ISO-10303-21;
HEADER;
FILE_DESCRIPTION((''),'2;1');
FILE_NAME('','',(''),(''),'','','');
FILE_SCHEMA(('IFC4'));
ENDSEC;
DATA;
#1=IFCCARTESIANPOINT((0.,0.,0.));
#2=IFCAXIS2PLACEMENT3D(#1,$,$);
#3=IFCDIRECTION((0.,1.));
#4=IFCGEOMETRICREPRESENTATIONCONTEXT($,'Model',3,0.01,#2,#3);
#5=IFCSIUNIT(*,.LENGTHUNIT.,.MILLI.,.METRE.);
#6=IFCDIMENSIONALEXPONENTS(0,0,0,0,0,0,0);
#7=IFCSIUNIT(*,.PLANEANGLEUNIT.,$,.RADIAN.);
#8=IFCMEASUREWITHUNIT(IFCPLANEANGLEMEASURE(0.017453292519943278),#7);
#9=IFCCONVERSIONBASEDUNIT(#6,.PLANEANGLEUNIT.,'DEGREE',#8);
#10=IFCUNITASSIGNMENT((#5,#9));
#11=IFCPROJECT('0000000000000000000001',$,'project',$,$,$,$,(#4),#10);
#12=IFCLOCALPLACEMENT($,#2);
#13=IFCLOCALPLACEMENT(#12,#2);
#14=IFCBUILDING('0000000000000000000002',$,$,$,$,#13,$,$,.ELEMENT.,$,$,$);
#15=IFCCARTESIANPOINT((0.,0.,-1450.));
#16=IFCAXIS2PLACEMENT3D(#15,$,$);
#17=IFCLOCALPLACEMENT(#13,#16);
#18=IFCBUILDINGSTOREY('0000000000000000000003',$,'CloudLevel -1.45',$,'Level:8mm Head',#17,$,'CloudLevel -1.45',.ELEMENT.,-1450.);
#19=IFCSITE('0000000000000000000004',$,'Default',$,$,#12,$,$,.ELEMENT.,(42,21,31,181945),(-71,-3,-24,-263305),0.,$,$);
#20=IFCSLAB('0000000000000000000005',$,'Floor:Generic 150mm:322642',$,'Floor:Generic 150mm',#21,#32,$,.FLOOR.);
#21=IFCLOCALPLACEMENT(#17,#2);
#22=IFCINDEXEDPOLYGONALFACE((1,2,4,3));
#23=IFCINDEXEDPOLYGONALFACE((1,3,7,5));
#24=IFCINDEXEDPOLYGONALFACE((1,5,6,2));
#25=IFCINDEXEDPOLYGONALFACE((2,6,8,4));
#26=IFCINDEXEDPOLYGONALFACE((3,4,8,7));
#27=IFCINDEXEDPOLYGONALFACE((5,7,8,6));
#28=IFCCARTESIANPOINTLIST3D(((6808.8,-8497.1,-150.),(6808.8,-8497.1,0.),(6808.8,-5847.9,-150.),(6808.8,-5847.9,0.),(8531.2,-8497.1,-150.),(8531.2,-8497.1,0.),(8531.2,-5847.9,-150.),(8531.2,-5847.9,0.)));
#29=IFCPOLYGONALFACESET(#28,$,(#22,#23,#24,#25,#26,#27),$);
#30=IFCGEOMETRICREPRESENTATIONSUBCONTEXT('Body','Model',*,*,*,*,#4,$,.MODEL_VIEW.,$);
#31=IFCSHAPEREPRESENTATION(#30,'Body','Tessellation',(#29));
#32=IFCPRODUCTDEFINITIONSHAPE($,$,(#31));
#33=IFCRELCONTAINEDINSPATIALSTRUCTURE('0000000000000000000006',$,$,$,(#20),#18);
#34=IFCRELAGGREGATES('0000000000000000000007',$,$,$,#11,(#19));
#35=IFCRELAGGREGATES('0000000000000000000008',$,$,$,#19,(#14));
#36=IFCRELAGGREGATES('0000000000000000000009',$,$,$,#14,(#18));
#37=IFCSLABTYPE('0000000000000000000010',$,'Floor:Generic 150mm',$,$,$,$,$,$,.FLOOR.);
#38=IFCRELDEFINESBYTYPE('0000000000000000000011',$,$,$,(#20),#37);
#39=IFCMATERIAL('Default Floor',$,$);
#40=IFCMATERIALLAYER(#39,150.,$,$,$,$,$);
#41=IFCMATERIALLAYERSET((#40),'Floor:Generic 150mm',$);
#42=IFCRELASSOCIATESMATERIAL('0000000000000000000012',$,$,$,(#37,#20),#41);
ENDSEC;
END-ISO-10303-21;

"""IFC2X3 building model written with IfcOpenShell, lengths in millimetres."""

from ifc_helpers import new_model, entity, si_unit, converted_unit, direction, frame, origin, origin_2d_with_axis, place, context, subcontext, project, spatial, rectangle, extrude, material, layer, layer_set, layer_usage, type_object, element, save


model = new_model("IFC2X3")

# Units and contexts
model_context = context("Model", 3, precision=0.01, world=origin(), true_north=direction((0.0, 1.0)))
body_context = subcontext(model_context, "Body", "Model", "MODEL_VIEW")
ifc_project = project(units=[si_unit("LENGTHUNIT", "METRE", prefix="MILLI"), converted_unit("PLANEANGLEUNIT", "DEGREE", entity("IfcPlaneAngleMeasure", 0.017453292519943278), si_unit("PLANEANGLEUNIT", "RADIAN"), dimensions=[0, 0, 0, 0, 0, 0, 0])], contexts=[model_context])

# Site, building, storey
site_placement = place(None, origin())
site = spatial("IfcSite", under=ifc_project, at=site_placement, Name="Default", CompositionType="ELEMENT", RefLatitude=(42, 21, 31, 181945), RefLongitude=(-71, -3, -24, -263305), RefElevation=0.0)
building_placement = place(site_placement, origin())
building = spatial("IfcBuilding", under=site, at=building_placement, CompositionType="ELEMENT")
storey_placement = place(building_placement, frame((0.0, 0.0, -1450.0)))
storey = spatial("IfcBuildingStorey", under=building, at=storey_placement, Name="CloudLevel -1.45", ObjectType="Level:8mm Head", LongName="CloudLevel -1.45", CompositionType="ELEMENT", Elevation=-1450.0)

# Slab
ifc_material_1 = material(Name="Default Floor")
ifc_layer_1 = layer(ifc_material_1, 150.0)
ifc_layer_set_1 = layer_set([ifc_layer_1], Name="Floor:Generic 150mm")
ifc_layer_usage_1 = layer_usage(ifc_layer_set_1, "AXIS3", "POSITIVE", 0.0)
slab_type = type_object("IfcSlabType", Name="Floor:Generic 150mm", PredefinedType="FLOOR", material=ifc_layer_set_1)
slab_1_placement = place(storey_placement, origin())
element("IfcSlab", 1, at=slab_1_placement, inside=storey, type_object=slab_type, material=ifc_layer_usage_1, Name="Floor:Generic 150mm:322642", ObjectType="Floor:Generic 150mm", PredefinedType="FLOOR", context=body_context, shape_type="SweptSolid", body=[
    extrude(rectangle(XDim=2649.3, YDim=1722.4, at=origin_2d_with_axis()), frame((7670.0, -7172.5, 0.0), z_axis=(0.0, 0.0, -1.0), x_axis=(0.0, 1.0, 0.0)), (0.0, 0.0, 1.0), 150.0),
])

save(model, "model.ifc")
